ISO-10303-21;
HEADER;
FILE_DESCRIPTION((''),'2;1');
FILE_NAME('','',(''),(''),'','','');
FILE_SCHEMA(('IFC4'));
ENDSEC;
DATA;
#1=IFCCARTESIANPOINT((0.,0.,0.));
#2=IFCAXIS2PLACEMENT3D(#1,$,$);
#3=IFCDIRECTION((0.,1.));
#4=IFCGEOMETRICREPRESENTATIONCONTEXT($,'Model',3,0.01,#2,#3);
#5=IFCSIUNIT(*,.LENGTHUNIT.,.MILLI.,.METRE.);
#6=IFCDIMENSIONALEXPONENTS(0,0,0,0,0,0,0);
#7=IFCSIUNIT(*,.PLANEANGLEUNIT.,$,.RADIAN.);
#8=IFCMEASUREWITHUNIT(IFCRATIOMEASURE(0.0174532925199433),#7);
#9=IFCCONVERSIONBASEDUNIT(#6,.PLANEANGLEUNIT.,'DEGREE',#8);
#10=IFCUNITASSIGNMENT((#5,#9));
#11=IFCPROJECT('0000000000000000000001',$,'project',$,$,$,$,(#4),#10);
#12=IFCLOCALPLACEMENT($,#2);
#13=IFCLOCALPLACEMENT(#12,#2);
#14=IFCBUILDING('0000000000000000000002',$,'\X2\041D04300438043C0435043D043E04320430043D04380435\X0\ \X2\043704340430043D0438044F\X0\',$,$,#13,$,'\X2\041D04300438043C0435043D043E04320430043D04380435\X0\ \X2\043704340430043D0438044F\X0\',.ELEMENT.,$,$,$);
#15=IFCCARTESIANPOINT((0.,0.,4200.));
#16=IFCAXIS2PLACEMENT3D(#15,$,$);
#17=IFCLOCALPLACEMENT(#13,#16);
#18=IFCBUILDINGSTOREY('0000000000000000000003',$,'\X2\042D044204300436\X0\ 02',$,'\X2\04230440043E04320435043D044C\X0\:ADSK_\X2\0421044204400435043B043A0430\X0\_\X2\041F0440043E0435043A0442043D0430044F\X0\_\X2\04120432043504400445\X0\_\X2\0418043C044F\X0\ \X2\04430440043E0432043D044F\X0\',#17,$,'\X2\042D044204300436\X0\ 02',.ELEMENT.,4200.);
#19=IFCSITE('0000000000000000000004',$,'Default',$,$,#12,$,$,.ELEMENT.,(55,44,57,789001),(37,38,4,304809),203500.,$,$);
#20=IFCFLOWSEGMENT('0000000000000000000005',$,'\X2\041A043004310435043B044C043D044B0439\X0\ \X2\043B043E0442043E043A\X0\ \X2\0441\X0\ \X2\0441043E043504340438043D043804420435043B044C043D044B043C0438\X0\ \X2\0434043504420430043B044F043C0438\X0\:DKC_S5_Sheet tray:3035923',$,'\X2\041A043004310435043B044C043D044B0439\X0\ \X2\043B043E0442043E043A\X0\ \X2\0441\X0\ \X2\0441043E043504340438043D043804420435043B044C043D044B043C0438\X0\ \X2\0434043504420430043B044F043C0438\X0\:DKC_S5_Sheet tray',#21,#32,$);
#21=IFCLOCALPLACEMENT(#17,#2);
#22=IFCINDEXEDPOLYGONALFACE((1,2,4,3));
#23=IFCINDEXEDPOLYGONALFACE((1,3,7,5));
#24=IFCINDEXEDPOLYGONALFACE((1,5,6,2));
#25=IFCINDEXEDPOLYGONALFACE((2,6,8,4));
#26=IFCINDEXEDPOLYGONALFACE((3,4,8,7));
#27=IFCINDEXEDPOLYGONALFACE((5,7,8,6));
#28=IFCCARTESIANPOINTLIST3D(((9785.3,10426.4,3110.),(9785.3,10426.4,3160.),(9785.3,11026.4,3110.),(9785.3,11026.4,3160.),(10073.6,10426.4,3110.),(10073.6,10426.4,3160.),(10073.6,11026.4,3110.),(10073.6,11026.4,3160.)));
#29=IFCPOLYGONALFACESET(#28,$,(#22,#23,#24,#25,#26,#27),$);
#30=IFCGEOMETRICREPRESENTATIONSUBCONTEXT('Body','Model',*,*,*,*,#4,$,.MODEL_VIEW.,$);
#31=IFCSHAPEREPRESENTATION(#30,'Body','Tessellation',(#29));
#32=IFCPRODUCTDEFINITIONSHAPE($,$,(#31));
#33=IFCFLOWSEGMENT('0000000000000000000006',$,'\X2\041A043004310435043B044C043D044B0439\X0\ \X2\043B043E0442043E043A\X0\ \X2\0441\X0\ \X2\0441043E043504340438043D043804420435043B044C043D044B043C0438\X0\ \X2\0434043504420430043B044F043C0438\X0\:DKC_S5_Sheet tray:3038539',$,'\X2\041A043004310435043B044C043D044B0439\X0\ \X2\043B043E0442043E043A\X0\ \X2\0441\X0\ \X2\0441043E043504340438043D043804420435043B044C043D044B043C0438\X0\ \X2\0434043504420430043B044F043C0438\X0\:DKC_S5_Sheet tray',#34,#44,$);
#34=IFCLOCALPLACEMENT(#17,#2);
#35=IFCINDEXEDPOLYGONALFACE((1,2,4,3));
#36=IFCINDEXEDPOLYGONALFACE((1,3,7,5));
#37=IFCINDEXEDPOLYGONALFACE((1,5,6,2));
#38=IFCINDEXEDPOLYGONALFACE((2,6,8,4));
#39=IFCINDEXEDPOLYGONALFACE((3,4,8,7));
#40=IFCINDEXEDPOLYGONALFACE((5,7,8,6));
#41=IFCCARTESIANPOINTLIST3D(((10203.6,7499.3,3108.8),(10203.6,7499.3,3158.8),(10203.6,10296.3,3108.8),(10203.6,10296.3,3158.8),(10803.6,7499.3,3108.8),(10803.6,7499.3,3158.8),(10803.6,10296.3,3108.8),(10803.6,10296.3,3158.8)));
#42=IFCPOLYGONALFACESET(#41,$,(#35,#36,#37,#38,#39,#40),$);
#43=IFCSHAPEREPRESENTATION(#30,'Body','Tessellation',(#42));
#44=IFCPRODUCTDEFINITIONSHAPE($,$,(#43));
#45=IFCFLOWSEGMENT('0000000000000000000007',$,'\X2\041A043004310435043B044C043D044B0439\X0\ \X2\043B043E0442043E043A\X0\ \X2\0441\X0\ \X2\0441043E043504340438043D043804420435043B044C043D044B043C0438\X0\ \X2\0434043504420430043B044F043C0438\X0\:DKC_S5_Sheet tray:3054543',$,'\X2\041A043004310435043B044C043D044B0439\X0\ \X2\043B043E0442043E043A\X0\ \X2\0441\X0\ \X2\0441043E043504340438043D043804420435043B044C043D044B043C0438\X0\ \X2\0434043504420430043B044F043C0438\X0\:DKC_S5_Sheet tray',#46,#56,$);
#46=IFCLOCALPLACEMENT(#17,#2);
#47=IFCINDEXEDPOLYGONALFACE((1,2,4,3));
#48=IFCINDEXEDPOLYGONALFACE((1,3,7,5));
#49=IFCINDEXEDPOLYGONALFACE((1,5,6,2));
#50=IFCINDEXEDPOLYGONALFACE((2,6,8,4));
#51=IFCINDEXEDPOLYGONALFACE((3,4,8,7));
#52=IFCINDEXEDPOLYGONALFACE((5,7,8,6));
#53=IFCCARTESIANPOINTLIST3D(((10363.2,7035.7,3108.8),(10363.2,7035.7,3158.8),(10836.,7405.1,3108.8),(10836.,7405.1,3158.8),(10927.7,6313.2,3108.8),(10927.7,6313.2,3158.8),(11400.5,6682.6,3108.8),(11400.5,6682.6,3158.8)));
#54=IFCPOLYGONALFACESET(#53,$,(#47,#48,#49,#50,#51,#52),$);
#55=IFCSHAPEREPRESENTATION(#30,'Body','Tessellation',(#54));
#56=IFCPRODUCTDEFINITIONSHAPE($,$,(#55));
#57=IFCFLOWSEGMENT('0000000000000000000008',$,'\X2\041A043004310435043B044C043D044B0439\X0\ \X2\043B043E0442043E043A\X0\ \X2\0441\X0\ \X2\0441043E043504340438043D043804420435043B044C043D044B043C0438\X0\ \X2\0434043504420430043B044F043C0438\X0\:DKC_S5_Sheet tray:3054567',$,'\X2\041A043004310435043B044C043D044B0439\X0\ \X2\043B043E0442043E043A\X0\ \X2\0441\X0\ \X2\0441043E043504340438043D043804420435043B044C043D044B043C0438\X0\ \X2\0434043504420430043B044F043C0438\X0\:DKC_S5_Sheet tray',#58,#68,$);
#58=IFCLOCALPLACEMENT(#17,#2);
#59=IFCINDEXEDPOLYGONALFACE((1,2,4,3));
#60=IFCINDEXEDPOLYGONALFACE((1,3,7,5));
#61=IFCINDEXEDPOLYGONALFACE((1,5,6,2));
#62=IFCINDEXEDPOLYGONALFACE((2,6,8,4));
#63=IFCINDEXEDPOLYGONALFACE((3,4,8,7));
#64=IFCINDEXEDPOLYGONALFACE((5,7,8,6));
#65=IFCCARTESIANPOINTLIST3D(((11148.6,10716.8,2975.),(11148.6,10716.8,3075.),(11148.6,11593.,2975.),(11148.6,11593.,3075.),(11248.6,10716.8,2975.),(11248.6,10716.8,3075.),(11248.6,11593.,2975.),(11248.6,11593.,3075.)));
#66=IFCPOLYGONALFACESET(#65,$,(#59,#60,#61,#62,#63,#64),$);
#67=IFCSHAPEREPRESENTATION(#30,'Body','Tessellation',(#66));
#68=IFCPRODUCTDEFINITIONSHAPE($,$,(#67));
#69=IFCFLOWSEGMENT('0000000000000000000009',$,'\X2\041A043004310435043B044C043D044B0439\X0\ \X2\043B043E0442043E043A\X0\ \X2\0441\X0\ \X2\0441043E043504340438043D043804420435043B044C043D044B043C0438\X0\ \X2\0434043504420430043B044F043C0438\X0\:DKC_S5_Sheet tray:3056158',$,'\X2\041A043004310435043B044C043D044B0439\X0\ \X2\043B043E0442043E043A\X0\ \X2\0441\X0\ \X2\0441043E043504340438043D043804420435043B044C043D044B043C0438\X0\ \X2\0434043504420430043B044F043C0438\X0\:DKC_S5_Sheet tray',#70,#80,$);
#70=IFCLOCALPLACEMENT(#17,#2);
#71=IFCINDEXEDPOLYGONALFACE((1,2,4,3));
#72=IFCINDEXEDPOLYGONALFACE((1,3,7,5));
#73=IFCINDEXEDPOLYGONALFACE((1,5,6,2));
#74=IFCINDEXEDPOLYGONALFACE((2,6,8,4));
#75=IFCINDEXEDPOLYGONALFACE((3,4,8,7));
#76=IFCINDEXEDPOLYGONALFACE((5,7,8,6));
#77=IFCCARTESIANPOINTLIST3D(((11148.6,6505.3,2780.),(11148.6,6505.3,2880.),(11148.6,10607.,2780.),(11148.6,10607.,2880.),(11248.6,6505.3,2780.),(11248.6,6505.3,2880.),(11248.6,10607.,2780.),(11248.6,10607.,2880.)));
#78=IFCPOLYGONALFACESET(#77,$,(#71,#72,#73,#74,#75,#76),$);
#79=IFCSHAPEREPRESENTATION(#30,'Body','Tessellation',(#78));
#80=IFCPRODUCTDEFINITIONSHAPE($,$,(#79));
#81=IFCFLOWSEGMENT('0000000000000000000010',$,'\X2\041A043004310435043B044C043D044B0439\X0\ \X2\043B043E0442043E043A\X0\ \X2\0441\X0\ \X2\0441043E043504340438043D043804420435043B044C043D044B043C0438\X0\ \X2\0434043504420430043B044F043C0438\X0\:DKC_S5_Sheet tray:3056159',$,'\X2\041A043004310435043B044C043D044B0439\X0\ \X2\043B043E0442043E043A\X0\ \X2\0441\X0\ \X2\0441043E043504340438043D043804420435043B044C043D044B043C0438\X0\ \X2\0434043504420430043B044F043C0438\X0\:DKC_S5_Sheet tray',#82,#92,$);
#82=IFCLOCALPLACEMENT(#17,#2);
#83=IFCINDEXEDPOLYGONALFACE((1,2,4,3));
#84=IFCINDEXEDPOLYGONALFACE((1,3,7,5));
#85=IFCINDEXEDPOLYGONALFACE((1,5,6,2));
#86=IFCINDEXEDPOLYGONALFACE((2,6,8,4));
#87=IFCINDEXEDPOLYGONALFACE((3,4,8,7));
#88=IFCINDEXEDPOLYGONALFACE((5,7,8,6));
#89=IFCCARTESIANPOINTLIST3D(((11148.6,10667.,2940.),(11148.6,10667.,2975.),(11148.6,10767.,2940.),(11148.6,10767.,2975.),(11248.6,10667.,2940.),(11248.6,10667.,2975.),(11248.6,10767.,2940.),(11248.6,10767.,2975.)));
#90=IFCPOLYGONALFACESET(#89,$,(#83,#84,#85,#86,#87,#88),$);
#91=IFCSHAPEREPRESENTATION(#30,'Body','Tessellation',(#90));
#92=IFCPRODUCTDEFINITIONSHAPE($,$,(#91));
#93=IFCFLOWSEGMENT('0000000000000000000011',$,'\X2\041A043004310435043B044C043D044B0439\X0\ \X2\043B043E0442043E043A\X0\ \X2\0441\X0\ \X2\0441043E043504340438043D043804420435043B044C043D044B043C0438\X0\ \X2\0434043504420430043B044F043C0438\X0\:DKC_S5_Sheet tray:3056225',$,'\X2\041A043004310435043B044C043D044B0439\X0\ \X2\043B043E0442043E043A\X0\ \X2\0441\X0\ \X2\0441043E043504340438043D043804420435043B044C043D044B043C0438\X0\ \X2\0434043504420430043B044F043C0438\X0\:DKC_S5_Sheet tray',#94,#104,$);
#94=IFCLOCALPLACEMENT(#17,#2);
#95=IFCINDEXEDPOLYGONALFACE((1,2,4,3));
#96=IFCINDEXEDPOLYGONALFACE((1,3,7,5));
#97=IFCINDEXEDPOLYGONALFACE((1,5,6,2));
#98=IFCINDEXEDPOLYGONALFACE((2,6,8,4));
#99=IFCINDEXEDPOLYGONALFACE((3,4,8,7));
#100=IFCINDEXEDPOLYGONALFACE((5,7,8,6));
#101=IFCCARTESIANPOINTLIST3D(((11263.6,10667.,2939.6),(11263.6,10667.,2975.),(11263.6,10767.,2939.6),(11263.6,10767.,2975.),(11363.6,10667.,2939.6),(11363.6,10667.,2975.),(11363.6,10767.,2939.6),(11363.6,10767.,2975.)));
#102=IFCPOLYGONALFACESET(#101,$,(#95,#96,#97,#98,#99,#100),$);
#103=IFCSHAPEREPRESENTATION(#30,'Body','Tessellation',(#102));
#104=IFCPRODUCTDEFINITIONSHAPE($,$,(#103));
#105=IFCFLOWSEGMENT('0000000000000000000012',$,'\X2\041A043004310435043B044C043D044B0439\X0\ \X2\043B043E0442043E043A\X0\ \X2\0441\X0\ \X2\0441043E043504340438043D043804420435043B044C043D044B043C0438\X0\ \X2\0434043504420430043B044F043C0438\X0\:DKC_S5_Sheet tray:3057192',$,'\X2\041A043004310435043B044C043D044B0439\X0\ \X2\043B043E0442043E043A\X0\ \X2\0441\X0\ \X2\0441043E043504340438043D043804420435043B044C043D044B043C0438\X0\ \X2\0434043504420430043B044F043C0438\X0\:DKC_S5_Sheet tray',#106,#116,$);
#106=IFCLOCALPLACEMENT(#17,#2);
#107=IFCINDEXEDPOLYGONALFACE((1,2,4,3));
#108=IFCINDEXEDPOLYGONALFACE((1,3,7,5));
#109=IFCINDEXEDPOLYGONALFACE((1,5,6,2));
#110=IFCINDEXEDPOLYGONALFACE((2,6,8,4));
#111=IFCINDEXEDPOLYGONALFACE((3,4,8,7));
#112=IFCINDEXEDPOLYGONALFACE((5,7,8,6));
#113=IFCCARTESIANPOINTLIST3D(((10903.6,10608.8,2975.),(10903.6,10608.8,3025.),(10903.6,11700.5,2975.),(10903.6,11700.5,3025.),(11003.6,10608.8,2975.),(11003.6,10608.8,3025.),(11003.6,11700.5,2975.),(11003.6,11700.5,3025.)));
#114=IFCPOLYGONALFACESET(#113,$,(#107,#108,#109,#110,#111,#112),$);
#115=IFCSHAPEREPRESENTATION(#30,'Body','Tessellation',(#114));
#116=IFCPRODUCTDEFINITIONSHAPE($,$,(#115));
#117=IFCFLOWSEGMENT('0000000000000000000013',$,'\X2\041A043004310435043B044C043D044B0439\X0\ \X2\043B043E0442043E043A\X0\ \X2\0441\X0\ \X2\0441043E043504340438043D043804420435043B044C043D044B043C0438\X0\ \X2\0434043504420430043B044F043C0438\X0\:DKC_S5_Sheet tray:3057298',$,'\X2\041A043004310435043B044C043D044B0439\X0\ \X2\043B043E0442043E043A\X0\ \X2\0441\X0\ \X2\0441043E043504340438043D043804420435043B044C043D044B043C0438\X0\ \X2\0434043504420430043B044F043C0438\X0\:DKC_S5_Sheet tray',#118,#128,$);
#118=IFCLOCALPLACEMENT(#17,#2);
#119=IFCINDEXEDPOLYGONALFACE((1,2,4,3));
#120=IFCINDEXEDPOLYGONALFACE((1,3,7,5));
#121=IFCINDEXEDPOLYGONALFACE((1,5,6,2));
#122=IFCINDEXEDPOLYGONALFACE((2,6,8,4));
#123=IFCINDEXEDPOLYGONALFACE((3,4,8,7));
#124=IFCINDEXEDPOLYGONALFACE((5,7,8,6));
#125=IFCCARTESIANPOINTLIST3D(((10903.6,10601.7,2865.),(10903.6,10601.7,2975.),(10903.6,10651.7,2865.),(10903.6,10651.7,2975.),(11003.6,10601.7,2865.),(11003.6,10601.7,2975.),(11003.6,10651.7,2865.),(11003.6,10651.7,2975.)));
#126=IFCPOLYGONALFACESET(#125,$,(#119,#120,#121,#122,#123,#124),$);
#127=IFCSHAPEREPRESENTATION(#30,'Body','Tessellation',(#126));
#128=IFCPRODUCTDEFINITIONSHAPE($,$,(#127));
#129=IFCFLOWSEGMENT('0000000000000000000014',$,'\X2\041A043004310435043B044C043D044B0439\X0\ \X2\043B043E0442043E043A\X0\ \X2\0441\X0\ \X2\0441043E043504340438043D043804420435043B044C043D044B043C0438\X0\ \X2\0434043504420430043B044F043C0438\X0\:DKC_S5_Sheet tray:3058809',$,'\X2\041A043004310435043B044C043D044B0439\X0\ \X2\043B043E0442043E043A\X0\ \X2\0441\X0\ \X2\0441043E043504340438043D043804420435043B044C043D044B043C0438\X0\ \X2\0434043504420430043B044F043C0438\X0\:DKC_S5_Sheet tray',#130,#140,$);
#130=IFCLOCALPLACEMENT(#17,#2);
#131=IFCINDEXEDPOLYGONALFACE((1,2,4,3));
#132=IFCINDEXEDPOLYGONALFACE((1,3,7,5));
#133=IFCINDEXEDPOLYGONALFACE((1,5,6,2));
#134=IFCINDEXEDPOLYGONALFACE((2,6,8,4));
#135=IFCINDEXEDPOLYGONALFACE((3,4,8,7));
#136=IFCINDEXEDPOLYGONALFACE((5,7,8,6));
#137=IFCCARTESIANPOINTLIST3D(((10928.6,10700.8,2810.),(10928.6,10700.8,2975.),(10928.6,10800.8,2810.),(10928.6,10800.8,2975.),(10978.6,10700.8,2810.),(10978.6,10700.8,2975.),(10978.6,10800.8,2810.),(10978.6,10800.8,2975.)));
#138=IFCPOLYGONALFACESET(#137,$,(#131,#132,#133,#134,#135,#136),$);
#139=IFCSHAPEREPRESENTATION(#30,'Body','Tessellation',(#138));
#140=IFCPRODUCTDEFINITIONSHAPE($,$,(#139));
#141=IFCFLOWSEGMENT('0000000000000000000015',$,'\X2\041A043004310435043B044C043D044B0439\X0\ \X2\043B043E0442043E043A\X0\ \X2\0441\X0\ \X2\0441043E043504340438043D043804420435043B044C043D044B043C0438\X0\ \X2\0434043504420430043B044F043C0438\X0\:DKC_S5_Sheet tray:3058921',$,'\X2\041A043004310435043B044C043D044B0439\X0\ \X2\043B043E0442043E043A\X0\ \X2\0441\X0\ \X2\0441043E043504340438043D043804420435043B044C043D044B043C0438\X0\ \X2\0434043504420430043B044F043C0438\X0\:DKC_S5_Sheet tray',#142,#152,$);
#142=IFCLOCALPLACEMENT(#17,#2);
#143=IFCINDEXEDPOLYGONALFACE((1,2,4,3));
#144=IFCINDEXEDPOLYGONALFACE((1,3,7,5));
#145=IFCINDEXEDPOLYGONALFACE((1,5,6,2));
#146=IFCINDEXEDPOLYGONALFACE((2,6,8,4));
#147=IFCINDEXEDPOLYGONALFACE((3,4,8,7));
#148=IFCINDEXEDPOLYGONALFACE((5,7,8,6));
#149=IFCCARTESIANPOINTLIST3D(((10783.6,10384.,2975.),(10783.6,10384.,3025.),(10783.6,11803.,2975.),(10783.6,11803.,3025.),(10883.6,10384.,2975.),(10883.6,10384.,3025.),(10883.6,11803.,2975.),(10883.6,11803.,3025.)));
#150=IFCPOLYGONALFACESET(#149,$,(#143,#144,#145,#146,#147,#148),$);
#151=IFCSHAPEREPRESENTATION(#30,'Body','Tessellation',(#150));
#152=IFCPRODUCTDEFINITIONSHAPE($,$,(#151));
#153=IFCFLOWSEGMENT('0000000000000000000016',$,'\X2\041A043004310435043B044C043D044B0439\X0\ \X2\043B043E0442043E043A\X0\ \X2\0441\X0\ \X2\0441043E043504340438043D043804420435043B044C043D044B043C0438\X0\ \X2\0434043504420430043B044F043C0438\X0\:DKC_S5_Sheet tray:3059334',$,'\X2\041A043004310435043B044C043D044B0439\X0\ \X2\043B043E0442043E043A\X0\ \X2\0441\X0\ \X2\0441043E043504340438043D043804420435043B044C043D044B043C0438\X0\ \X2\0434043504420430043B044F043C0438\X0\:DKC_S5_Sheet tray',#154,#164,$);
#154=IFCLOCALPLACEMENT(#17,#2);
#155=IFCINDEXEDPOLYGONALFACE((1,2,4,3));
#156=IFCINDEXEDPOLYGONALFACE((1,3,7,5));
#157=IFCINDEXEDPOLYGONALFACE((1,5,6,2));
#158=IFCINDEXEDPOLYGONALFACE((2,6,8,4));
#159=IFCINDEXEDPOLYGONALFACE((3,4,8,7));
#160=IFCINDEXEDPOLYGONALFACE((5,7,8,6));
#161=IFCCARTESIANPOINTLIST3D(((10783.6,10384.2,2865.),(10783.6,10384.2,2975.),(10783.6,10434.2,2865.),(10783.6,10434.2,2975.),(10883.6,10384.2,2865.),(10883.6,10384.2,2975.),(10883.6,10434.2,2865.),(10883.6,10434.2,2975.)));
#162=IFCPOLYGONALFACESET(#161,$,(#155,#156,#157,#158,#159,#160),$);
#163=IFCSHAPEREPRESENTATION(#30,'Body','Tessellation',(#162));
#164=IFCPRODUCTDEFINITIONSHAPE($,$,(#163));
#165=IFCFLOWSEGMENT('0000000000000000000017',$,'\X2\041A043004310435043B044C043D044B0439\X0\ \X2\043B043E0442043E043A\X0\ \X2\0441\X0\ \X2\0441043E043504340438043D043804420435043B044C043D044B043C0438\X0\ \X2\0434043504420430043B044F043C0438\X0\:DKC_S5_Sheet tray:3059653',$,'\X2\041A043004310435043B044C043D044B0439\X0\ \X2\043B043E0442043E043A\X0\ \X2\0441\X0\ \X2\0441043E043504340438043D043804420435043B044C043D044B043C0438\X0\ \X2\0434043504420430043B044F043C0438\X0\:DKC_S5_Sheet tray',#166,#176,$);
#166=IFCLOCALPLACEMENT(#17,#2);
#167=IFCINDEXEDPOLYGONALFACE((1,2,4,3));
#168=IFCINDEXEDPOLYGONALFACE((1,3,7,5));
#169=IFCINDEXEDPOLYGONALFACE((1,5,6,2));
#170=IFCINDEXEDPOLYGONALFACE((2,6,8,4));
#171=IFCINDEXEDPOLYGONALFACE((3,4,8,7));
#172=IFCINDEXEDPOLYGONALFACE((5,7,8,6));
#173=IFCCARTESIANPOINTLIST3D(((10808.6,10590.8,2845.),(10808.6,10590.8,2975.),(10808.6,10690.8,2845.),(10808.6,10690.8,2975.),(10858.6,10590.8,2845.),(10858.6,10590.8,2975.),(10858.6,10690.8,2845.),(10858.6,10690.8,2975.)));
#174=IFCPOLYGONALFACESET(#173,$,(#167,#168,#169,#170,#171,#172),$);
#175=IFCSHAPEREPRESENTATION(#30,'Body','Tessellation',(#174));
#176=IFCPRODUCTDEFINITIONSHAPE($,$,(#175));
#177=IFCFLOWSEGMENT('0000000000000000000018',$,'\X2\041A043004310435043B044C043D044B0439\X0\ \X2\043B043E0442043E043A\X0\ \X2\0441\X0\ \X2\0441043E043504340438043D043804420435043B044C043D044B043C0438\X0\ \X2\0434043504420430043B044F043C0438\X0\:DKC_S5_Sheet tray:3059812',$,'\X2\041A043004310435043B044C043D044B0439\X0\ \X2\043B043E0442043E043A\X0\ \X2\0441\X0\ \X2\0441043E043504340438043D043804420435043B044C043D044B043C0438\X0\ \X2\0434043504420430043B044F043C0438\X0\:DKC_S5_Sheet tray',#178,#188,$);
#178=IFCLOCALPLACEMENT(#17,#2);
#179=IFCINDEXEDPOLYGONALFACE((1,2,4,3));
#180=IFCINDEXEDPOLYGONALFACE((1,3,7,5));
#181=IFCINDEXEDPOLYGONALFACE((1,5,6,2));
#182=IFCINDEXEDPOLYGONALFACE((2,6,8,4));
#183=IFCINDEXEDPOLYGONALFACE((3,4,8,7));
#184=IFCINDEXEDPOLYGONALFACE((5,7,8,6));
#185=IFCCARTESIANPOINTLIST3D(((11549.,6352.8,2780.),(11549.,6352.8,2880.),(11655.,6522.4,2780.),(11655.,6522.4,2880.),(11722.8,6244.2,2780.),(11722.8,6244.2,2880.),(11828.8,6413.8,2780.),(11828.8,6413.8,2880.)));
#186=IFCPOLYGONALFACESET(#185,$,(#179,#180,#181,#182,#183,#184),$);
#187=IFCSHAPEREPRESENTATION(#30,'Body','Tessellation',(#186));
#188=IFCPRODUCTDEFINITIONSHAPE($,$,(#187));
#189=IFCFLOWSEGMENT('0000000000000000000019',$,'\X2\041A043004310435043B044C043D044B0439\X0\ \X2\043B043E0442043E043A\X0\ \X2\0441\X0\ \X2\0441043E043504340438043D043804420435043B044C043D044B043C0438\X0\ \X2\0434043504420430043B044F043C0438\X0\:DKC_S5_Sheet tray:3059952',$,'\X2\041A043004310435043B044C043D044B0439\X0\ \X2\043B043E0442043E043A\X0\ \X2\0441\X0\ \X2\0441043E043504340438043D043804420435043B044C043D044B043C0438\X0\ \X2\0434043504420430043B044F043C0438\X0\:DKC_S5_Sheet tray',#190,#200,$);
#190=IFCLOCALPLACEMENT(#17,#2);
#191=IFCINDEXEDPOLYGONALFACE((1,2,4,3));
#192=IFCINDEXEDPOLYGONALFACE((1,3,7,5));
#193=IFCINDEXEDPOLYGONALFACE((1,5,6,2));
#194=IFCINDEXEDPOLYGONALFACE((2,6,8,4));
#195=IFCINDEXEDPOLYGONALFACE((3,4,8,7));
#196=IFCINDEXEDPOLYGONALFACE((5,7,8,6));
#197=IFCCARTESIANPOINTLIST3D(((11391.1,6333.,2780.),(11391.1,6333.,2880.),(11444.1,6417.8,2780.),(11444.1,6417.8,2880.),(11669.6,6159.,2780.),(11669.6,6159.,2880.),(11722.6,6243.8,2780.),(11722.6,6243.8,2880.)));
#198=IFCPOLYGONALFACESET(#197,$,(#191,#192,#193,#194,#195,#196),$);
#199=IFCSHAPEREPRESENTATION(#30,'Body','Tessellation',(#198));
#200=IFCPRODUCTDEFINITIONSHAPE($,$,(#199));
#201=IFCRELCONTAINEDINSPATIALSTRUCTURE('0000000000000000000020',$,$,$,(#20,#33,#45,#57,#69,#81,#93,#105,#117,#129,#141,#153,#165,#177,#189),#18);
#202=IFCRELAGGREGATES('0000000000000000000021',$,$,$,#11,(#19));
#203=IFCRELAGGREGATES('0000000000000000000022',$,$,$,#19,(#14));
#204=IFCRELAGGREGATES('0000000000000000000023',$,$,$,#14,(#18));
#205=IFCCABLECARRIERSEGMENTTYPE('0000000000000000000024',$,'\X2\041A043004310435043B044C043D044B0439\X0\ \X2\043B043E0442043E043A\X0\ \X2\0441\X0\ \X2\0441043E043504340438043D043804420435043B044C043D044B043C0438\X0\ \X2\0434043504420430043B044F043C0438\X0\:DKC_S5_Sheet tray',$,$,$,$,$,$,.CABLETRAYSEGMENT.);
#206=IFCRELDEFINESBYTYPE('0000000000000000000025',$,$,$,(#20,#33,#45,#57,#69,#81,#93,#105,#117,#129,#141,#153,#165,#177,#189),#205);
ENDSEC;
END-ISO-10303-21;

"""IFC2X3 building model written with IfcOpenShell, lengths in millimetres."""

from ifc_helpers import new_model, entity, si_unit, converted_unit, direction, frame, origin, origin_2d_with_axis, place, context, subcontext, project, spatial, rectangle, extrude, type_object, element, save


model = new_model("IFC2X3")

# Units and contexts
model_context = context("Model", 3, precision=0.01, world=origin(), true_north=direction((0.0, 1.0)))
body_context = subcontext(model_context, "Body", "Model", "MODEL_VIEW")
ifc_project = project(units=[si_unit("LENGTHUNIT", "METRE", prefix="MILLI"), converted_unit("PLANEANGLEUNIT", "DEGREE", entity("IfcRatioMeasure", 0.0174532925199433), si_unit("PLANEANGLEUNIT", "RADIAN"), dimensions=[0, 0, 0, 0, 0, 0, 0])], contexts=[model_context])

# Site, building, storey
site_placement = place(None, origin())
site = spatial("IfcSite", under=ifc_project, at=site_placement, Name="Default", CompositionType="ELEMENT", RefLatitude=(55, 44, 57, 789001), RefLongitude=(37, 38, 4, 304809), RefElevation=203500.0)
building_placement = place(site_placement, origin())
building = spatial("IfcBuilding", under=site, at=building_placement, Name="Наименование здания", LongName="Наименование здания", CompositionType="ELEMENT")
storey_placement = place(building_placement, frame((0.0, 0.0, 4200.0)))
storey = spatial("IfcBuildingStorey", under=building, at=storey_placement, Name="Этаж 02", ObjectType="Уровень:ADSK_Стрелка_Проектная_Вверх_Имя уровня", LongName="Этаж 02", CompositionType="ELEMENT", Elevation=4200.0)

# Flow segments
cable_carrier_segment_type = type_object("IfcCableCarrierSegmentType", Name="Кабельный лоток с соединительными деталями:DKC_S5_Sheet tray", PredefinedType="CABLETRAYSEGMENT")
flow_segment_1_placement = place(storey_placement, frame((9785.3, 10426.4, 3110.0)))
element("IfcFlowSegment", 1, at=flow_segment_1_placement, inside=storey, type_object=cable_carrier_segment_type, Name="Кабельный лоток с соединительными деталями:DKC_S5_Sheet tray:3035923", ObjectType="Кабельный лоток с соединительными деталями:DKC_S5_Sheet tray", context=body_context, shape_type="SweptSolid", body=[
    extrude(rectangle(XDim=288.3, YDim=600.0, at=origin_2d_with_axis()), frame((144.2, 300.0, 0.0), z_axis=(0.0, 0.0, 1.0), x_axis=(-1.0, 0.0, 0.0)), (0.0, 0.0, 1.0), 50.0),
])
flow_segment_2_placement = place(storey_placement, frame((10203.6, 7499.3, 3108.8)))
element("IfcFlowSegment", 2, at=flow_segment_2_placement, inside=storey, type_object=cable_carrier_segment_type, Name="Кабельный лоток с соединительными деталями:DKC_S5_Sheet tray:3038539", ObjectType="Кабельный лоток с соединительными деталями:DKC_S5_Sheet tray", context=body_context, shape_type="SweptSolid", body=[
    extrude(rectangle(XDim=2797.1, YDim=600.0, at=origin_2d_with_axis()), frame((300.0, 1398.5, 0.0), z_axis=(0.0, 0.0, 1.0), x_axis=(0.0, -1.0, 0.0)), (0.0, 0.0, 1.0), 50.0),
])
flow_segment_3_placement = place(storey_placement, frame((10363.2, 6313.2, 3108.8)))
element("IfcFlowSegment", 3, at=flow_segment_3_placement, inside=storey, type_object=cable_carrier_segment_type, Name="Кабельный лоток с соединительными деталями:DKC_S5_Sheet tray:3054543", ObjectType="Кабельный лоток с соединительными деталями:DKC_S5_Sheet tray", context=body_context, shape_type="SweptSolid", body=[
    extrude(rectangle(XDim=917.0, YDim=600.0, at=origin_2d_with_axis()), frame((518.7, 546.0, 0.0), z_axis=(0.0, 0.0, 1.0), x_axis=(0.615661, -0.788011, 0.0)), (0.0, 0.0, 1.0), 50.0),
])
flow_segment_4_placement = place(storey_placement, frame((11148.6, 10716.9, 2975.0)))
element("IfcFlowSegment", 4, at=flow_segment_4_placement, inside=storey, type_object=cable_carrier_segment_type, Name="Кабельный лоток с соединительными деталями:DKC_S5_Sheet tray:3054567", ObjectType="Кабельный лоток с соединительными деталями:DKC_S5_Sheet tray", context=body_context, shape_type="SweptSolid", body=[
    extrude(rectangle(XDim=876.1, YDim=100.0, at=origin_2d_with_axis()), frame((50.0, 438.1, 0.0), z_axis=(0.0, 0.0, 1.0), x_axis=(0.0, -1.0, 0.0)), (0.0, 0.0, 1.0), 100.0),
])
flow_segment_5_placement = place(storey_placement, frame((11148.6, 6505.3, 2780.0)))
element("IfcFlowSegment", 5, at=flow_segment_5_placement, inside=storey, type_object=cable_carrier_segment_type, Name="Кабельный лоток с соединительными деталями:DKC_S5_Sheet tray:3056158", ObjectType="Кабельный лоток с соединительными деталями:DKC_S5_Sheet tray", context=body_context, shape_type="SweptSolid", body=[
    extrude(rectangle(XDim=4101.8, YDim=100.0, at=origin_2d_with_axis()), frame((50.0, 2050.9, 0.0), z_axis=(0.0, 0.0, 1.0), x_axis=(0.0, -1.0, 0.0)), (0.0, 0.0, 1.0), 100.0),
])
flow_segment_6_placement = place(storey_placement, frame((11148.6, 10667.0, 2940.0)))
element("IfcFlowSegment", 6, at=flow_segment_6_placement, inside=storey, type_object=cable_carrier_segment_type, Name="Кабельный лоток с соединительными деталями:DKC_S5_Sheet tray:3056159", ObjectType="Кабельный лоток с соединительными деталями:DKC_S5_Sheet tray", context=body_context, shape_type="SweptSolid", body=[
    extrude(rectangle(XDim=100.0, YDim=100.0, at=origin_2d_with_axis()), frame((50.0, 50.0, 0.0), z_axis=(0.0, 0.0, 1.0), x_axis=(-1.0, 0.0, 0.0)), (0.0, 0.0, 1.0), 35.0),
])
flow_segment_7_placement = place(storey_placement, frame((11263.6, 10667.0, 2939.6)))
element("IfcFlowSegment", 7, at=flow_segment_7_placement, inside=storey, type_object=cable_carrier_segment_type, Name="Кабельный лоток с соединительными деталями:DKC_S5_Sheet tray:3056225", ObjectType="Кабельный лоток с соединительными деталями:DKC_S5_Sheet tray", context=body_context, shape_type="SweptSolid", body=[
    extrude(rectangle(XDim=100.0, YDim=100.0, at=origin_2d_with_axis()), frame((50.0, 50.0, 0.0), z_axis=(0.0, 0.0, 1.0), x_axis=(-1.0, 0.0, 0.0)), (0.0, 0.0, 1.0), 35.4),
])
flow_segment_8_placement = place(storey_placement, frame((10903.6, 10608.8, 2975.0)))
element("IfcFlowSegment", 8, at=flow_segment_8_placement, inside=storey, type_object=cable_carrier_segment_type, Name="Кабельный лоток с соединительными деталями:DKC_S5_Sheet tray:3057192", ObjectType="Кабельный лоток с соединительными деталями:DKC_S5_Sheet tray", context=body_context, shape_type="SweptSolid", body=[
    extrude(rectangle(XDim=1091.7, YDim=100.0, at=origin_2d_with_axis()), frame((50.0, 545.9, 0.0), z_axis=(0.0, 0.0, 1.0), x_axis=(0.0, -1.0, 0.0)), (0.0, 0.0, 1.0), 50.0),
])
flow_segment_9_placement = place(storey_placement, frame((10903.6, 10601.7, 2865.0)))
element("IfcFlowSegment", 9, at=flow_segment_9_placement, inside=storey, type_object=cable_carrier_segment_type, Name="Кабельный лоток с соединительными деталями:DKC_S5_Sheet tray:3057298", ObjectType="Кабельный лоток с соединительными деталями:DKC_S5_Sheet tray", context=body_context, shape_type="SweptSolid", body=[
    extrude(rectangle(XDim=50.0, YDim=100.0, at=origin_2d_with_axis()), frame((50.0, 25.0, 0.0), z_axis=(0.0, 0.0, 1.0), x_axis=(0.0, -1.0, 0.0)), (0.0, 0.0, 1.0), 110.0),
])
flow_segment_10_placement = place(storey_placement, frame((10928.6, 10700.8, 2810.0)))
element("IfcFlowSegment", 10, at=flow_segment_10_placement, inside=storey, type_object=cable_carrier_segment_type, Name="Кабельный лоток с соединительными деталями:DKC_S5_Sheet tray:3058809", ObjectType="Кабельный лоток с соединительными деталями:DKC_S5_Sheet tray", context=body_context, shape_type="SweptSolid", body=[
    extrude(rectangle(XDim=100.0, YDim=50.0, at=origin_2d_with_axis()), frame((25.0, 50.0, 0.0), z_axis=(0.0, 0.0, 1.0), x_axis=(0.0, -1.0, 0.0)), (0.0, 0.0, 1.0), 165.0),
])
flow_segment_11_placement = place(storey_placement, frame((10783.6, 10384.0, 2975.0)))
element("IfcFlowSegment", 11, at=flow_segment_11_placement, inside=storey, type_object=cable_carrier_segment_type, Name="Кабельный лоток с соединительными деталями:DKC_S5_Sheet tray:3058921", ObjectType="Кабельный лоток с соединительными деталями:DKC_S5_Sheet tray", context=body_context, shape_type="SweptSolid", body=[
    extrude(rectangle(XDim=1419.0, YDim=100.0, at=origin_2d_with_axis()), frame((50.0, 709.5, 0.0), z_axis=(0.0, 0.0, 1.0), x_axis=(0.0, -1.0, 0.0)), (0.0, 0.0, 1.0), 50.0),
])
flow_segment_12_placement = place(storey_placement, frame((10783.6, 10384.2, 2865.0)))
element("IfcFlowSegment", 12, at=flow_segment_12_placement, inside=storey, type_object=cable_carrier_segment_type, Name="Кабельный лоток с соединительными деталями:DKC_S5_Sheet tray:3059334", ObjectType="Кабельный лоток с соединительными деталями:DKC_S5_Sheet tray", context=body_context, shape_type="SweptSolid", body=[
    extrude(rectangle(XDim=100.0, YDim=50.0, at=origin_2d_with_axis()), frame((50.0, 25.0, 0.0), z_axis=(0.0, 0.0, 1.0), x_axis=(-1.0, 0.0, 0.0)), (0.0, 0.0, 1.0), 110.0),
])
flow_segment_13_placement = place(storey_placement, frame((10808.6, 10590.8, 2845.0)))
element("IfcFlowSegment", 13, at=flow_segment_13_placement, inside=storey, type_object=cable_carrier_segment_type, Name="Кабельный лоток с соединительными деталями:DKC_S5_Sheet tray:3059653", ObjectType="Кабельный лоток с соединительными деталями:DKC_S5_Sheet tray", context=body_context, shape_type="SweptSolid", body=[
    extrude(rectangle(XDim=100.0, YDim=50.0, at=origin_2d_with_axis()), frame((25.0, 50.0, 0.0), z_axis=(0.0, 0.0, 1.0), x_axis=(0.0, 1.0, 0.0)), (0.0, 0.0, 1.0), 130.0),
])
flow_segment_14_placement = place(storey_placement, frame((11549.0, 6244.1, 2780.0)))
element("IfcFlowSegment", 14, at=flow_segment_14_placement, inside=storey, type_object=cable_carrier_segment_type, Name="Кабельный лоток с соединительными деталями:DKC_S5_Sheet tray:3059812", ObjectType="Кабельный лоток с соединительными деталями:DKC_S5_Sheet tray", context=body_context, shape_type="SweptSolid", body=[
    extrude(rectangle(XDim=205.0, YDim=200.0, at=origin_2d_with_axis()), frame((139.9, 139.1, 0.0), z_axis=(0.0, 0.0, 1.0), x_axis=(-0.848048, 0.529919, 0.0)), (0.0, 0.0, 1.0), 100.0),
])
flow_segment_15_placement = place(storey_placement, frame((11391.1, 6159.0, 2780.0)))
element("IfcFlowSegment", 15, at=flow_segment_15_placement, inside=storey, type_object=cable_carrier_segment_type, Name="Кабельный лоток с соединительными деталями:DKC_S5_Sheet tray:3059952", ObjectType="Кабельный лоток с соединительными деталями:DKC_S5_Sheet tray", context=body_context, shape_type="SweptSolid", body=[
    extrude(rectangle(XDim=328.4, YDim=100.0, at=origin_2d_with_axis()), frame((165.7, 129.4, 0.0), z_axis=(0.0, 0.0, 1.0), x_axis=(-0.848048, 0.529919, 0.0)), (0.0, 0.0, 1.0), 100.0),
])

save(model, "model.ifc")
